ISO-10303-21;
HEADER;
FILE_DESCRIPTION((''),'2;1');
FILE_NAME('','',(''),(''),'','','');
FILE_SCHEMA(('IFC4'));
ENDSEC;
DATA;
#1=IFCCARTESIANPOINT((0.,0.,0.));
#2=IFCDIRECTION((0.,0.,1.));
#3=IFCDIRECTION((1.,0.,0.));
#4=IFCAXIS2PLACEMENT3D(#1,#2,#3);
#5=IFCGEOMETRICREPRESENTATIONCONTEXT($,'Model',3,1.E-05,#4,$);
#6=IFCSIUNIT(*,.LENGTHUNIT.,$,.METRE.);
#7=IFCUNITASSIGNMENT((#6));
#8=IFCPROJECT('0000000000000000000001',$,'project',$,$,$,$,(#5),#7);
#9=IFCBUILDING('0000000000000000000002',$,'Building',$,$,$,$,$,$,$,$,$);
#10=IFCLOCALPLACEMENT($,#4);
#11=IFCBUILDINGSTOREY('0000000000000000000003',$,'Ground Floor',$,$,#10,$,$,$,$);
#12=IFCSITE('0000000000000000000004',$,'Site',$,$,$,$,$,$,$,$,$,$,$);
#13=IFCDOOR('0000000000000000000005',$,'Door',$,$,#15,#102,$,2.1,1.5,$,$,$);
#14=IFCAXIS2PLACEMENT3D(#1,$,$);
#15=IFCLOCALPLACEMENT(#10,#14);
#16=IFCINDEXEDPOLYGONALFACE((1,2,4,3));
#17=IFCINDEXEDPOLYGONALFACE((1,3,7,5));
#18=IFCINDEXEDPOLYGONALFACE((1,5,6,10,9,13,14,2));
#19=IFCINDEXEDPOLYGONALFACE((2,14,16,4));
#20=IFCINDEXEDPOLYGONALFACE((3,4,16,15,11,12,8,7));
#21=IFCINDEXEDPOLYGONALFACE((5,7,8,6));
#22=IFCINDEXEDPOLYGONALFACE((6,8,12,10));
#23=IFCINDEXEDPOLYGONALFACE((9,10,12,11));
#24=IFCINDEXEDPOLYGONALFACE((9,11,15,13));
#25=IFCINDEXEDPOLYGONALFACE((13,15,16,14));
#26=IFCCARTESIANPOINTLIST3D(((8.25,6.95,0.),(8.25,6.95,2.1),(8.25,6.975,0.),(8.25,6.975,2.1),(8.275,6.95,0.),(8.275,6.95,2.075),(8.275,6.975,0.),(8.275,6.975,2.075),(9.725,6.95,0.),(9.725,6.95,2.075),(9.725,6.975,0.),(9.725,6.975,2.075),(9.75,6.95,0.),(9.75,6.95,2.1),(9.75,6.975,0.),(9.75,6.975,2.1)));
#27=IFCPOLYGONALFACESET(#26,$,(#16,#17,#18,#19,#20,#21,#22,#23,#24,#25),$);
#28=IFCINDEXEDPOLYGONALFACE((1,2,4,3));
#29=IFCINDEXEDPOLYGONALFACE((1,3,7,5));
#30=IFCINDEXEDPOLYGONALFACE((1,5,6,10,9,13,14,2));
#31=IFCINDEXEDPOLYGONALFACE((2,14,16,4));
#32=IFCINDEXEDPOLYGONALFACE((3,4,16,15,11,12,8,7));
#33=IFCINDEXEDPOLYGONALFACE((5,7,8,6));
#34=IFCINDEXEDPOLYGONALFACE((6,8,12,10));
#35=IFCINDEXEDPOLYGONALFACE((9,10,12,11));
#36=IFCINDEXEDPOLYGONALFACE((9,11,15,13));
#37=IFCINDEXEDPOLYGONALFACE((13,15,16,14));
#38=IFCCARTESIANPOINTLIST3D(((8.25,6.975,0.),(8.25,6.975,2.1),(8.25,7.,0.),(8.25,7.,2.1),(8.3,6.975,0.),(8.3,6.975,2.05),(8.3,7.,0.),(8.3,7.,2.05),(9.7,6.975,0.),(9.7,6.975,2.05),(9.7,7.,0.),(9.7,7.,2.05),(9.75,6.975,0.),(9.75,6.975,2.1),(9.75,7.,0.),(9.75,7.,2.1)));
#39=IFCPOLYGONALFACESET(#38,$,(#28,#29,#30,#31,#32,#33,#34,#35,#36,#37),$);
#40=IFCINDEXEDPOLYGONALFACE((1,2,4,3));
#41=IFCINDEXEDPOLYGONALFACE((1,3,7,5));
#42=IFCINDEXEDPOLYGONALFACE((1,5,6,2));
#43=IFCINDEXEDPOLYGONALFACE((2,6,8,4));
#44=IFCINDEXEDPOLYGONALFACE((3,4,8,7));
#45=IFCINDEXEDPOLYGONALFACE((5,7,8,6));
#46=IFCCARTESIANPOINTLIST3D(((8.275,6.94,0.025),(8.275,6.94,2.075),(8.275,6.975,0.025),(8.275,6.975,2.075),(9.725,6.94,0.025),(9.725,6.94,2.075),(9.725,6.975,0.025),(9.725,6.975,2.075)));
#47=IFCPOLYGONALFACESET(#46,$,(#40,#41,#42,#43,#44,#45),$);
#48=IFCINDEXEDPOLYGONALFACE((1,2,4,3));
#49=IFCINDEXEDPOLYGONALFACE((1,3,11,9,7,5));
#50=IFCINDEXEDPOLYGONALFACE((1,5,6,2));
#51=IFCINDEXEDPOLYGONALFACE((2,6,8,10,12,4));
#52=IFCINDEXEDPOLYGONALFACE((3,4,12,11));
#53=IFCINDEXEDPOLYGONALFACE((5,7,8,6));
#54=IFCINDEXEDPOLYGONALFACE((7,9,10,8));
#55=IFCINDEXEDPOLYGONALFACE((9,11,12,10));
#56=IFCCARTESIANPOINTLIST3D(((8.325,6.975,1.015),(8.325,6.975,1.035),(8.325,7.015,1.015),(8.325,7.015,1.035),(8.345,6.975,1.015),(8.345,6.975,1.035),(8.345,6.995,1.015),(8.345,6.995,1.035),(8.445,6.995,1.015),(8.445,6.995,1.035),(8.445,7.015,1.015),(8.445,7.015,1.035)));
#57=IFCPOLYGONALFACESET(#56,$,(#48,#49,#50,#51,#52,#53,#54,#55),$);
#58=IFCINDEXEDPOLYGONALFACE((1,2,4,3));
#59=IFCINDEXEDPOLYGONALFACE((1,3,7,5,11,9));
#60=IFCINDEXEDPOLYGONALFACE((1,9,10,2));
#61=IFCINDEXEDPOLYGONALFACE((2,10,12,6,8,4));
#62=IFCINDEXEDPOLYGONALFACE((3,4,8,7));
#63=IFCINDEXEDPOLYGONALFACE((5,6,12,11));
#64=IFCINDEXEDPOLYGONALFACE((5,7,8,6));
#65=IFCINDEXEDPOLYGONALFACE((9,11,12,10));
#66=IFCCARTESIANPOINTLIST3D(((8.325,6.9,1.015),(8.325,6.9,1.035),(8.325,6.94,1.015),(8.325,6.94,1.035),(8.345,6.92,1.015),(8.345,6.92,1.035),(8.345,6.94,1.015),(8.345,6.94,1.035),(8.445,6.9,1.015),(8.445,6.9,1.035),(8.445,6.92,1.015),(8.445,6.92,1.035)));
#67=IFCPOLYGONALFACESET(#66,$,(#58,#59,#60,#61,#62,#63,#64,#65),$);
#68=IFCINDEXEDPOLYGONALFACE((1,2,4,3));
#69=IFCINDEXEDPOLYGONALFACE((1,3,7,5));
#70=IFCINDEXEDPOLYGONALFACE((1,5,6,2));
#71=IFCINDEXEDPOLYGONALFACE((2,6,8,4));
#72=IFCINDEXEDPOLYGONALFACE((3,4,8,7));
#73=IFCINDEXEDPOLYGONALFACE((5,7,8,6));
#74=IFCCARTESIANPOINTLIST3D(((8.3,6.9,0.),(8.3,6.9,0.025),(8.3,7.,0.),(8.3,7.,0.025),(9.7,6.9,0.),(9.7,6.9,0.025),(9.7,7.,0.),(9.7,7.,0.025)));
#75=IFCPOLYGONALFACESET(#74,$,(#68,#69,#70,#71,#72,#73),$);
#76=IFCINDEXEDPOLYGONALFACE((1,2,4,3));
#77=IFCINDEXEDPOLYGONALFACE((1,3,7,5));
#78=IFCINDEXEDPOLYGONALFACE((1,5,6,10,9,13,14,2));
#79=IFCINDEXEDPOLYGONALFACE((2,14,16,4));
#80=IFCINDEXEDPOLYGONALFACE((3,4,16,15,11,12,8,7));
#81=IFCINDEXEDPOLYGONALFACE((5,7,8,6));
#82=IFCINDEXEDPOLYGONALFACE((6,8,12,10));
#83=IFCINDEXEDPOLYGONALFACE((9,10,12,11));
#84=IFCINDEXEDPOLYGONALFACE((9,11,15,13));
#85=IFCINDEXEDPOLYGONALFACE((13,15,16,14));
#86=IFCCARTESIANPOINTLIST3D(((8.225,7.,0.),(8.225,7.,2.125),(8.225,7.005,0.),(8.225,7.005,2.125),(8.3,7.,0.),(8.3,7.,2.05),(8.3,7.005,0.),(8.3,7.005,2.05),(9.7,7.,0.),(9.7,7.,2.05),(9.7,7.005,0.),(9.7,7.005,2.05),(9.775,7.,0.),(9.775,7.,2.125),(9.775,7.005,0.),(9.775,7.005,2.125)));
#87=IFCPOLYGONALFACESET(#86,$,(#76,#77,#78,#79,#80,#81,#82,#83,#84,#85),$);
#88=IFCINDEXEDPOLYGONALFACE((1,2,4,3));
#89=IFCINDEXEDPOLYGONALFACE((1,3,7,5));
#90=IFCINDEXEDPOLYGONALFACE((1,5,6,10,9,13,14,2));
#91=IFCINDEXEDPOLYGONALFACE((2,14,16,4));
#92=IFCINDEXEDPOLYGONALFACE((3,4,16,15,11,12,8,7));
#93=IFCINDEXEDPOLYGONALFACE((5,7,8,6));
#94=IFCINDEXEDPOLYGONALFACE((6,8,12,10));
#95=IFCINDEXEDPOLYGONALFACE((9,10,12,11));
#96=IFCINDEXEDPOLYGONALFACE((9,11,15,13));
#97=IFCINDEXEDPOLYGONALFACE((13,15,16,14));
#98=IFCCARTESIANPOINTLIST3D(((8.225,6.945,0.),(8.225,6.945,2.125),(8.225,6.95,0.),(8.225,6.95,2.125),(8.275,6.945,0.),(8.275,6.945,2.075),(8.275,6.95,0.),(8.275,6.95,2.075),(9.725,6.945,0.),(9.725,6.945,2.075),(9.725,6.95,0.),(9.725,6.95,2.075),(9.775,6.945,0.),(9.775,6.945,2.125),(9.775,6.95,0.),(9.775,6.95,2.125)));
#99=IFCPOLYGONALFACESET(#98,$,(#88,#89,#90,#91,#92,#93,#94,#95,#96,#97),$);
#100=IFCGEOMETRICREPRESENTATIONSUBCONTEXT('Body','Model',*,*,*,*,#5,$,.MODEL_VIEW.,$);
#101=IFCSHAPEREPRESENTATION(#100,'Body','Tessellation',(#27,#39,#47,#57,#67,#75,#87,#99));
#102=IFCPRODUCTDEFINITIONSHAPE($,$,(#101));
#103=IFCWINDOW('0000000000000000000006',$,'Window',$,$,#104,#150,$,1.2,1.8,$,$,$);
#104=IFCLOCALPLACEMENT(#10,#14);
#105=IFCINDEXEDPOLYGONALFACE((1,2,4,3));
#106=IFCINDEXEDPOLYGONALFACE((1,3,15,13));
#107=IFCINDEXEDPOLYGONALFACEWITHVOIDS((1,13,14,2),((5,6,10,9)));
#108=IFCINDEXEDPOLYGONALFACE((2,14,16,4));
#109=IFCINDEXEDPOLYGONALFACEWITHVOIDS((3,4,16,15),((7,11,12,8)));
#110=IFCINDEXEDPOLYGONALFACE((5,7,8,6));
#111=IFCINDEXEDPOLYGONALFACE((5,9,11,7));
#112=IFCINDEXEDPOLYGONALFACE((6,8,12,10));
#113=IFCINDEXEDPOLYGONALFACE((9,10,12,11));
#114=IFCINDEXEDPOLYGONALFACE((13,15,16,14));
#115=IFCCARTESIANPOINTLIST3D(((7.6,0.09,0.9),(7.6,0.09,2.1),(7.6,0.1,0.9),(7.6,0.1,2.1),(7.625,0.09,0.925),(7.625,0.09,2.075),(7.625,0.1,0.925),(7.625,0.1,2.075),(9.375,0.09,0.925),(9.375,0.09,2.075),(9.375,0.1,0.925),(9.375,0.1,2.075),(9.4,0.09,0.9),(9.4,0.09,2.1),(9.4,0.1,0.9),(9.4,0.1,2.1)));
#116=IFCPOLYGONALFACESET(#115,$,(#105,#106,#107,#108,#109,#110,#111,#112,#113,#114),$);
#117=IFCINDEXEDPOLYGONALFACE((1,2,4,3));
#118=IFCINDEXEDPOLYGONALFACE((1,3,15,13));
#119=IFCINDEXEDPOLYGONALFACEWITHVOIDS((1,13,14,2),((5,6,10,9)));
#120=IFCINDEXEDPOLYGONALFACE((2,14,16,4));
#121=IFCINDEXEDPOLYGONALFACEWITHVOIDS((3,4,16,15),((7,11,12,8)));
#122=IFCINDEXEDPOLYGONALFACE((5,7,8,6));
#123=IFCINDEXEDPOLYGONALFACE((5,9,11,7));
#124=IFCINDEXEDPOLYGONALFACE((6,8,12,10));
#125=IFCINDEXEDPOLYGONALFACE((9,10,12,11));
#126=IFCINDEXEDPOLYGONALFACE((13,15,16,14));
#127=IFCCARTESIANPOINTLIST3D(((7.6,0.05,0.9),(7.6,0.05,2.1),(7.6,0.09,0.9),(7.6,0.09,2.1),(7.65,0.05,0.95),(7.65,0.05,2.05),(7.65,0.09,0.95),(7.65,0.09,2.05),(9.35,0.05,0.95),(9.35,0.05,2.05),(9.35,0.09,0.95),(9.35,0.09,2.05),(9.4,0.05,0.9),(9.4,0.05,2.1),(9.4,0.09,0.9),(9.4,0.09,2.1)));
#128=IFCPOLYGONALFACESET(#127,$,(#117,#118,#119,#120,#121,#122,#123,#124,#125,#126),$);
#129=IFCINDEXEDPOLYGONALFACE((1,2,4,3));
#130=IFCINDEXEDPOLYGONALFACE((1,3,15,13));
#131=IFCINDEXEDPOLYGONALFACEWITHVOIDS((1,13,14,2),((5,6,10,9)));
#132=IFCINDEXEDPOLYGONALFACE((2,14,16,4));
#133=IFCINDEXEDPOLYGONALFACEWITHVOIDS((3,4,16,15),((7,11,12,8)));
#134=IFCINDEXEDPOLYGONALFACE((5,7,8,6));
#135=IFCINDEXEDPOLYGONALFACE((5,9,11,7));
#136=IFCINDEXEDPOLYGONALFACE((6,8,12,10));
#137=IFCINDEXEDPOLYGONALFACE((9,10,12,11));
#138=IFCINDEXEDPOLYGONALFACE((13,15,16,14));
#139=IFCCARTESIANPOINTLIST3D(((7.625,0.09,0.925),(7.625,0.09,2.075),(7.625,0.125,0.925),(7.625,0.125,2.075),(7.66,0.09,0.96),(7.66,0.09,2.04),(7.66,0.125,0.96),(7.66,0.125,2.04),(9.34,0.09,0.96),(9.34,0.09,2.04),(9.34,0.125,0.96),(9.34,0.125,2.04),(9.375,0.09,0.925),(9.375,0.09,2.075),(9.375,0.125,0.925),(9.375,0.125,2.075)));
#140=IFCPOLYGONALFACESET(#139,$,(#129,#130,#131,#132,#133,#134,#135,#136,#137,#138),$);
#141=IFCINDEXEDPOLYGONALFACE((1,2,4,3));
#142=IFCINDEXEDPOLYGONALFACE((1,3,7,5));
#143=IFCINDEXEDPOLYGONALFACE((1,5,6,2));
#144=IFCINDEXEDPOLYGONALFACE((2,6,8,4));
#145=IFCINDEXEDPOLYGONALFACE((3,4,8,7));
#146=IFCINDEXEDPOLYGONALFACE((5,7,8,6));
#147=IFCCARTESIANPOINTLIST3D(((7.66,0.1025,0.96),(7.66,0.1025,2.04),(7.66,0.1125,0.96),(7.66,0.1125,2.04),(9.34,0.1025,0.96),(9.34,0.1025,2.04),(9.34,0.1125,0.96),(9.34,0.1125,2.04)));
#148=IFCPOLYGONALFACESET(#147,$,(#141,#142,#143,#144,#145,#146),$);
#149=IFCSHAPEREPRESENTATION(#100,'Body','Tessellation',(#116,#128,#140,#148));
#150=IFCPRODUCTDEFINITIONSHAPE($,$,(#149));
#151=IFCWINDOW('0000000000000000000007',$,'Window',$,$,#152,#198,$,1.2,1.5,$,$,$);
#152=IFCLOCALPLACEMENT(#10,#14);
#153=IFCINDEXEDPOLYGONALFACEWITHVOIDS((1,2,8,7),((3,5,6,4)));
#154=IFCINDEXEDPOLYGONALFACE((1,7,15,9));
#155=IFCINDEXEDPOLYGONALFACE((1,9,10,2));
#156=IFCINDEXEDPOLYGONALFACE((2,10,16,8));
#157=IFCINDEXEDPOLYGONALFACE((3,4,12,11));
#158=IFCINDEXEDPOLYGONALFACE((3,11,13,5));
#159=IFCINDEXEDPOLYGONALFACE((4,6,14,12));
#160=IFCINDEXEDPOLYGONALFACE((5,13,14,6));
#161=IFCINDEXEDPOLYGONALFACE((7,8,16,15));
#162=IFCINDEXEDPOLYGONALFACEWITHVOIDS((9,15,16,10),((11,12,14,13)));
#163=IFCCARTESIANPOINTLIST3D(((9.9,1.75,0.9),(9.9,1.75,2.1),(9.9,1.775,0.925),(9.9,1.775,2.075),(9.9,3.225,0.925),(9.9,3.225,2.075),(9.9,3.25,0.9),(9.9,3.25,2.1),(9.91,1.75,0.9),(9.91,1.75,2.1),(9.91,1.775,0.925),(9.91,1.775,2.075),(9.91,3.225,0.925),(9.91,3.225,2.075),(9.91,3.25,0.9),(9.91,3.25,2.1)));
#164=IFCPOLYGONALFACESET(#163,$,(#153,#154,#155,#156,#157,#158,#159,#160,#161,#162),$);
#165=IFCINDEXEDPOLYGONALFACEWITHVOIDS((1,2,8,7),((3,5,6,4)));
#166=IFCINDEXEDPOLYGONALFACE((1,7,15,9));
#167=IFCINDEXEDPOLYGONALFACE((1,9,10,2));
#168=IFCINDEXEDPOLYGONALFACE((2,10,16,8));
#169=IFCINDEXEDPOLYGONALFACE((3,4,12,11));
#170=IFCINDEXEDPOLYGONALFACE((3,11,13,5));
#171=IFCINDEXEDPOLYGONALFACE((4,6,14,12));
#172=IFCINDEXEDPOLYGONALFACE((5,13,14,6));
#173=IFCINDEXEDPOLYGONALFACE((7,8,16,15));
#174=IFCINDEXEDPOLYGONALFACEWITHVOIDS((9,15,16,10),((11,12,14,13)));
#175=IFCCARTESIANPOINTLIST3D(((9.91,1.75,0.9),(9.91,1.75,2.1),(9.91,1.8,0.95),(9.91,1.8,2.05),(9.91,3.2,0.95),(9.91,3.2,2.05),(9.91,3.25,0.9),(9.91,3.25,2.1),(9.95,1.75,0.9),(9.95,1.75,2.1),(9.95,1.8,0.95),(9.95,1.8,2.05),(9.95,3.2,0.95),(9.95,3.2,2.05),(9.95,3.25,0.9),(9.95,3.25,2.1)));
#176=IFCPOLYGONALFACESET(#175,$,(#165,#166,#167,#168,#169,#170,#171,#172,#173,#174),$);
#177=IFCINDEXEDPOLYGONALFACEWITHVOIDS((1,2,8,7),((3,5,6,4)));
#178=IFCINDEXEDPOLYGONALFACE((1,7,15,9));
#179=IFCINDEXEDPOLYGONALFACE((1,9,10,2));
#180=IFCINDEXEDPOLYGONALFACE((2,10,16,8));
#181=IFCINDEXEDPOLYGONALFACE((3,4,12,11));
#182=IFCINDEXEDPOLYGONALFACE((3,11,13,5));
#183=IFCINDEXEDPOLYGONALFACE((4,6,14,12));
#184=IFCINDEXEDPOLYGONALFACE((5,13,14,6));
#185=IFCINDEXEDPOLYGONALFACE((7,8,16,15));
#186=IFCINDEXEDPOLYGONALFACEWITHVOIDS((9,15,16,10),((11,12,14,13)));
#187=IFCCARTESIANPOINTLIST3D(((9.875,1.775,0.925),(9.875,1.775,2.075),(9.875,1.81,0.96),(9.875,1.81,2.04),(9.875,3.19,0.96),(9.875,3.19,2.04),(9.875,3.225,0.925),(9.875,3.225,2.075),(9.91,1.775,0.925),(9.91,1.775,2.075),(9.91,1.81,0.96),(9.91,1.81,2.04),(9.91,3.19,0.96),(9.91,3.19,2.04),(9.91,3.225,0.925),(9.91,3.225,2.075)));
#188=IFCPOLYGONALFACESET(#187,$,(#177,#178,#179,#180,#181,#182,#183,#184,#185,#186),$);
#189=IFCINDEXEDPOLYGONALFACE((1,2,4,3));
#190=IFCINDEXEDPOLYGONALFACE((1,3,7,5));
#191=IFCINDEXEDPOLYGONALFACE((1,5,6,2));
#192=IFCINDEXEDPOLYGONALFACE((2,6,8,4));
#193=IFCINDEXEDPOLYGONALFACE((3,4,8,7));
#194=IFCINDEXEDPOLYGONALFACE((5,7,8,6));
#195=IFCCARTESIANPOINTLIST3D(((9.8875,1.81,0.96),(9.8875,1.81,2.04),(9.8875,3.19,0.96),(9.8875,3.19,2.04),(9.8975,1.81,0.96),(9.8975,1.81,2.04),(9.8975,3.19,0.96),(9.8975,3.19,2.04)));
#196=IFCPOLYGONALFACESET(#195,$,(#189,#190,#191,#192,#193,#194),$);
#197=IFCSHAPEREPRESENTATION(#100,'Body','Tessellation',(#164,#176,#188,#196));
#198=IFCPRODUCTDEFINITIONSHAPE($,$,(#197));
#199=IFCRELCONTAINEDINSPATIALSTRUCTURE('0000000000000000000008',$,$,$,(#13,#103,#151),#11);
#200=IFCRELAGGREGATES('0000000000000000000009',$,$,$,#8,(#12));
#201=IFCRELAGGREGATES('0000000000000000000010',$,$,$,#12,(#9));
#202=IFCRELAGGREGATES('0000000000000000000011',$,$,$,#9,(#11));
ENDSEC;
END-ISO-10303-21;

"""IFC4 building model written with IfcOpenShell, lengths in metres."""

from ifc_helpers import new_model, si_unit, frame, origin_with_axes, place, context, subcontext, project, spatial, line, indexed_curve, outline, extrude, element, save


model = new_model("IFC4")

# Units and contexts
model_context = context("Model", 3, precision=1e-05, world=origin_with_axes())
body_context = subcontext(model_context, "Body", "Model", "MODEL_VIEW")
ifc_project = project(units=[si_unit("LENGTHUNIT", "METRE")], contexts=[model_context])

# Site, building, storey
site = spatial("IfcSite", under=ifc_project, Name="Site")
building = spatial("IfcBuilding", under=site, Name="Building")
storey_placement = place(None, origin_with_axes())
storey = spatial("IfcBuildingStorey", under=building, at=storey_placement, Name="Ground Floor")

# Door
door_1_placement = place(storey_placement, frame((9.75, 7.0, 0.0), z_axis=(0.0, 0.0, 1.0), x_axis=(-1.0, 0.0, 0.0)))
element("IfcDoor", 1, at=door_1_placement, inside=storey, Name="Door", OverallHeight=2.1, OverallWidth=1.5, context=body_context, shape_type="SweptSolid", body=[
    extrude(outline(indexed_curve([(0.0, 0.0), (0.0, 2.1), (1.5, 2.1), (1.5, 0.0), (1.475, 0.0), (1.475, 2.075), (0.025, 2.075), (0.025, 0.0)], segments=[line(1, 2, 3, 4, 5, 6, 7, 8, 1)])), frame((0.0, 0.025, 0.0), z_axis=(0.0, -1.0, 0.0), x_axis=(1.0, 0.0, 0.0)), (0.0, 0.0, -1.0), 0.025),
    extrude(outline(indexed_curve([(0.0, 0.0), (0.0, 2.1), (1.5, 2.1), (1.5, 0.0), (1.45, 0.0), (1.45, 2.05), (0.05, 2.05), (0.05, 0.0)], segments=[line(1, 2, 3, 4, 5, 6, 7, 8, 1)])), frame((0.0, 0.0, 0.0), z_axis=(0.0, -1.0, 0.0), x_axis=(1.0, 0.0, 0.0)), (0.0, 0.0, -1.0), 0.025),
    extrude(outline(indexed_curve([(0.0, 0.0), (1.45, 0.0), (1.45, 0.035), (0.0, 0.035)], segments=[line(1, 2, 3, 4, 1)])), frame((0.025, 0.025, 0.025), z_axis=(0.0, 0.0, 1.0), x_axis=(1.0, 0.0, 0.0)), (0.0, 0.0, 1.0), 2.05),
    extrude(outline(indexed_curve([(0.0, 0.0), (0.0, -0.04), (-0.12, -0.04), (-0.12, -0.02), (-0.02, -0.02), (-0.02, 0.0)], segments=[line(1, 2, 3, 4, 5, 6, 1)])), frame((1.425, 0.025, 1.015), z_axis=(0.0, 0.0, 1.0), x_axis=(1.0, 0.0, 0.0)), (0.0, 0.0, 1.0), 0.02),
    extrude(outline(indexed_curve([(0.0, 0.0), (0.0, 0.04), (-0.12, 0.04), (-0.12, 0.02), (-0.02, 0.02), (-0.02, 0.0)], segments=[line(1, 2, 3, 4, 5, 6, 1)])), frame((1.425, 0.06, 1.015), z_axis=(0.0, 0.0, 1.0), x_axis=(1.0, 0.0, 0.0)), (0.0, 0.0, 1.0), 0.02),
    extrude(outline(indexed_curve([(0.0, 0.0), (1.4, 0.0), (1.4, 0.1), (0.0, 0.1)], segments=[line(1, 2, 3, 4, 1)])), frame((0.05, 0.0, 0.0), z_axis=(0.0, 0.0, 1.0), x_axis=(1.0, 0.0, 0.0)), (0.0, 0.0, 1.0), 0.025),
    extrude(outline(indexed_curve([(0.0, 0.0), (0.0, 2.125), (1.55, 2.125), (1.55, 0.0), (1.475, 0.0), (1.475, 2.05), (0.075, 2.05), (0.075, 0.0)], segments=[line(1, 2, 3, 4, 5, 6, 7, 8, 1)])), frame((-0.025, -0.005, 0.0), z_axis=(0.0, -1.0, 0.0), x_axis=(1.0, 0.0, 0.0)), (0.0, 0.0, -1.0), 0.005),
    extrude(outline(indexed_curve([(0.0, 0.0), (0.0, 2.125), (1.55, 2.125), (1.55, 0.0), (1.5, 0.0), (1.5, 2.075), (0.05, 2.075), (0.05, 0.0)], segments=[line(1, 2, 3, 4, 5, 6, 7, 8, 1)])), frame((-0.025, 0.05, 0.0), z_axis=(0.0, -1.0, 0.0), x_axis=(1.0, 0.0, 0.0)), (0.0, 0.0, -1.0), 0.005),
])

# Windows
window_1_placement = place(storey_placement, frame((7.6, 0.0, 0.9), z_axis=(0.0, 0.0, 1.0), x_axis=(1.0, 0.0, 0.0)))
element("IfcWindow", 2, at=window_1_placement, inside=storey, Name="Window", OverallHeight=1.2, OverallWidth=1.8, context=body_context, shape_type="SweptSolid", body=[
    extrude(outline(indexed_curve([(0.0, 0.0), (1.8, 0.0), (1.8, 1.2), (0.0, 1.2)], segments=[line(1, 2, 3, 4, 1)]), holes=[indexed_curve([(0.025, 0.025), (1.775, 0.025), (1.775, 1.175), (0.025, 1.175)], segments=[line(1, 2, 3, 4, 1)])]), frame((0.0, 0.09, 0.0), z_axis=(0.0, -1.0, 0.0), x_axis=(1.0, 0.0, 0.0)), (0.0, 0.0, -1.0), 0.01),
    extrude(outline(indexed_curve([(0.0, 0.0), (1.8, 0.0), (1.8, 1.2), (0.0, 1.2)], segments=[line(1, 2, 3, 4, 1)]), holes=[indexed_curve([(0.05, 0.05), (1.75, 0.05), (1.75, 1.15), (0.05, 1.15)], segments=[line(1, 2, 3, 4, 1)])]), frame((0.0, 0.05, 0.0), z_axis=(0.0, -1.0, 0.0), x_axis=(1.0, 0.0, 0.0)), (0.0, 0.0, -1.0), 0.04),
    extrude(outline(indexed_curve([(0.0, 0.0), (1.75, 0.0), (1.75, 1.15), (0.0, 1.15)], segments=[line(1, 2, 3, 4, 1)]), holes=[indexed_curve([(0.035, 0.035), (1.715, 0.035), (1.715, 1.115), (0.035, 1.115)], segments=[line(1, 2, 3, 4, 1)])]), frame((0.025, 0.09, 0.025), z_axis=(0.0, -1.0, 0.0), x_axis=(1.0, 0.0, 0.0)), (0.0, 0.0, -1.0), 0.035),
    extrude(outline(indexed_curve([(0.035, 0.035), (1.715, 0.035), (1.715, 1.115), (0.035, 1.115)], segments=[line(1, 2, 3, 4, 1)])), frame((0.025, 0.1025, 0.025), z_axis=(0.0, -1.0, 0.0), x_axis=(1.0, 0.0, 0.0)), (0.0, 0.0, -1.0), 0.01),
])
window_2_placement = place(storey_placement, frame((10.0, 1.75, 0.9), z_axis=(0.0, 0.0, 1.0), x_axis=(0.0, 1.0, 0.0)))
element("IfcWindow", 3, at=window_2_placement, inside=storey, Name="Window", OverallHeight=1.2, OverallWidth=1.5, context=body_context, shape_type="SweptSolid", body=[
    extrude(outline(indexed_curve([(0.0, 0.0), (1.5, 0.0), (1.5, 1.2), (0.0, 1.2)], segments=[line(1, 2, 3, 4, 1)]), holes=[indexed_curve([(0.025, 0.025), (1.475, 0.025), (1.475, 1.175), (0.025, 1.175)], segments=[line(1, 2, 3, 4, 1)])]), frame((0.0, 0.09, 0.0), z_axis=(0.0, -1.0, 0.0), x_axis=(1.0, 0.0, 0.0)), (0.0, 0.0, -1.0), 0.01),
    extrude(outline(indexed_curve([(0.0, 0.0), (1.5, 0.0), (1.5, 1.2), (0.0, 1.2)], segments=[line(1, 2, 3, 4, 1)]), holes=[indexed_curve([(0.05, 0.05), (1.45, 0.05), (1.45, 1.15), (0.05, 1.15)], segments=[line(1, 2, 3, 4, 1)])]), frame((0.0, 0.05, 0.0), z_axis=(0.0, -1.0, 0.0), x_axis=(1.0, 0.0, 0.0)), (0.0, 0.0, -1.0), 0.04),
    extrude(outline(indexed_curve([(0.0, 0.0), (1.45, 0.0), (1.45, 1.15), (0.0, 1.15)], segments=[line(1, 2, 3, 4, 1)]), holes=[indexed_curve([(0.035, 0.035), (1.415, 0.035), (1.415, 1.115), (0.035, 1.115)], segments=[line(1, 2, 3, 4, 1)])]), frame((0.025, 0.09, 0.025), z_axis=(0.0, -1.0, 0.0), x_axis=(1.0, 0.0, 0.0)), (0.0, 0.0, -1.0), 0.035),
    extrude(outline(indexed_curve([(0.035, 0.035), (1.415, 0.035), (1.415, 1.115), (0.035, 1.115)], segments=[line(1, 2, 3, 4, 1)])), frame((0.025, 0.1025, 0.025), z_axis=(0.0, -1.0, 0.0), x_axis=(1.0, 0.0, 0.0)), (0.0, 0.0, -1.0), 0.01),
])

save(model, "model.ifc")
